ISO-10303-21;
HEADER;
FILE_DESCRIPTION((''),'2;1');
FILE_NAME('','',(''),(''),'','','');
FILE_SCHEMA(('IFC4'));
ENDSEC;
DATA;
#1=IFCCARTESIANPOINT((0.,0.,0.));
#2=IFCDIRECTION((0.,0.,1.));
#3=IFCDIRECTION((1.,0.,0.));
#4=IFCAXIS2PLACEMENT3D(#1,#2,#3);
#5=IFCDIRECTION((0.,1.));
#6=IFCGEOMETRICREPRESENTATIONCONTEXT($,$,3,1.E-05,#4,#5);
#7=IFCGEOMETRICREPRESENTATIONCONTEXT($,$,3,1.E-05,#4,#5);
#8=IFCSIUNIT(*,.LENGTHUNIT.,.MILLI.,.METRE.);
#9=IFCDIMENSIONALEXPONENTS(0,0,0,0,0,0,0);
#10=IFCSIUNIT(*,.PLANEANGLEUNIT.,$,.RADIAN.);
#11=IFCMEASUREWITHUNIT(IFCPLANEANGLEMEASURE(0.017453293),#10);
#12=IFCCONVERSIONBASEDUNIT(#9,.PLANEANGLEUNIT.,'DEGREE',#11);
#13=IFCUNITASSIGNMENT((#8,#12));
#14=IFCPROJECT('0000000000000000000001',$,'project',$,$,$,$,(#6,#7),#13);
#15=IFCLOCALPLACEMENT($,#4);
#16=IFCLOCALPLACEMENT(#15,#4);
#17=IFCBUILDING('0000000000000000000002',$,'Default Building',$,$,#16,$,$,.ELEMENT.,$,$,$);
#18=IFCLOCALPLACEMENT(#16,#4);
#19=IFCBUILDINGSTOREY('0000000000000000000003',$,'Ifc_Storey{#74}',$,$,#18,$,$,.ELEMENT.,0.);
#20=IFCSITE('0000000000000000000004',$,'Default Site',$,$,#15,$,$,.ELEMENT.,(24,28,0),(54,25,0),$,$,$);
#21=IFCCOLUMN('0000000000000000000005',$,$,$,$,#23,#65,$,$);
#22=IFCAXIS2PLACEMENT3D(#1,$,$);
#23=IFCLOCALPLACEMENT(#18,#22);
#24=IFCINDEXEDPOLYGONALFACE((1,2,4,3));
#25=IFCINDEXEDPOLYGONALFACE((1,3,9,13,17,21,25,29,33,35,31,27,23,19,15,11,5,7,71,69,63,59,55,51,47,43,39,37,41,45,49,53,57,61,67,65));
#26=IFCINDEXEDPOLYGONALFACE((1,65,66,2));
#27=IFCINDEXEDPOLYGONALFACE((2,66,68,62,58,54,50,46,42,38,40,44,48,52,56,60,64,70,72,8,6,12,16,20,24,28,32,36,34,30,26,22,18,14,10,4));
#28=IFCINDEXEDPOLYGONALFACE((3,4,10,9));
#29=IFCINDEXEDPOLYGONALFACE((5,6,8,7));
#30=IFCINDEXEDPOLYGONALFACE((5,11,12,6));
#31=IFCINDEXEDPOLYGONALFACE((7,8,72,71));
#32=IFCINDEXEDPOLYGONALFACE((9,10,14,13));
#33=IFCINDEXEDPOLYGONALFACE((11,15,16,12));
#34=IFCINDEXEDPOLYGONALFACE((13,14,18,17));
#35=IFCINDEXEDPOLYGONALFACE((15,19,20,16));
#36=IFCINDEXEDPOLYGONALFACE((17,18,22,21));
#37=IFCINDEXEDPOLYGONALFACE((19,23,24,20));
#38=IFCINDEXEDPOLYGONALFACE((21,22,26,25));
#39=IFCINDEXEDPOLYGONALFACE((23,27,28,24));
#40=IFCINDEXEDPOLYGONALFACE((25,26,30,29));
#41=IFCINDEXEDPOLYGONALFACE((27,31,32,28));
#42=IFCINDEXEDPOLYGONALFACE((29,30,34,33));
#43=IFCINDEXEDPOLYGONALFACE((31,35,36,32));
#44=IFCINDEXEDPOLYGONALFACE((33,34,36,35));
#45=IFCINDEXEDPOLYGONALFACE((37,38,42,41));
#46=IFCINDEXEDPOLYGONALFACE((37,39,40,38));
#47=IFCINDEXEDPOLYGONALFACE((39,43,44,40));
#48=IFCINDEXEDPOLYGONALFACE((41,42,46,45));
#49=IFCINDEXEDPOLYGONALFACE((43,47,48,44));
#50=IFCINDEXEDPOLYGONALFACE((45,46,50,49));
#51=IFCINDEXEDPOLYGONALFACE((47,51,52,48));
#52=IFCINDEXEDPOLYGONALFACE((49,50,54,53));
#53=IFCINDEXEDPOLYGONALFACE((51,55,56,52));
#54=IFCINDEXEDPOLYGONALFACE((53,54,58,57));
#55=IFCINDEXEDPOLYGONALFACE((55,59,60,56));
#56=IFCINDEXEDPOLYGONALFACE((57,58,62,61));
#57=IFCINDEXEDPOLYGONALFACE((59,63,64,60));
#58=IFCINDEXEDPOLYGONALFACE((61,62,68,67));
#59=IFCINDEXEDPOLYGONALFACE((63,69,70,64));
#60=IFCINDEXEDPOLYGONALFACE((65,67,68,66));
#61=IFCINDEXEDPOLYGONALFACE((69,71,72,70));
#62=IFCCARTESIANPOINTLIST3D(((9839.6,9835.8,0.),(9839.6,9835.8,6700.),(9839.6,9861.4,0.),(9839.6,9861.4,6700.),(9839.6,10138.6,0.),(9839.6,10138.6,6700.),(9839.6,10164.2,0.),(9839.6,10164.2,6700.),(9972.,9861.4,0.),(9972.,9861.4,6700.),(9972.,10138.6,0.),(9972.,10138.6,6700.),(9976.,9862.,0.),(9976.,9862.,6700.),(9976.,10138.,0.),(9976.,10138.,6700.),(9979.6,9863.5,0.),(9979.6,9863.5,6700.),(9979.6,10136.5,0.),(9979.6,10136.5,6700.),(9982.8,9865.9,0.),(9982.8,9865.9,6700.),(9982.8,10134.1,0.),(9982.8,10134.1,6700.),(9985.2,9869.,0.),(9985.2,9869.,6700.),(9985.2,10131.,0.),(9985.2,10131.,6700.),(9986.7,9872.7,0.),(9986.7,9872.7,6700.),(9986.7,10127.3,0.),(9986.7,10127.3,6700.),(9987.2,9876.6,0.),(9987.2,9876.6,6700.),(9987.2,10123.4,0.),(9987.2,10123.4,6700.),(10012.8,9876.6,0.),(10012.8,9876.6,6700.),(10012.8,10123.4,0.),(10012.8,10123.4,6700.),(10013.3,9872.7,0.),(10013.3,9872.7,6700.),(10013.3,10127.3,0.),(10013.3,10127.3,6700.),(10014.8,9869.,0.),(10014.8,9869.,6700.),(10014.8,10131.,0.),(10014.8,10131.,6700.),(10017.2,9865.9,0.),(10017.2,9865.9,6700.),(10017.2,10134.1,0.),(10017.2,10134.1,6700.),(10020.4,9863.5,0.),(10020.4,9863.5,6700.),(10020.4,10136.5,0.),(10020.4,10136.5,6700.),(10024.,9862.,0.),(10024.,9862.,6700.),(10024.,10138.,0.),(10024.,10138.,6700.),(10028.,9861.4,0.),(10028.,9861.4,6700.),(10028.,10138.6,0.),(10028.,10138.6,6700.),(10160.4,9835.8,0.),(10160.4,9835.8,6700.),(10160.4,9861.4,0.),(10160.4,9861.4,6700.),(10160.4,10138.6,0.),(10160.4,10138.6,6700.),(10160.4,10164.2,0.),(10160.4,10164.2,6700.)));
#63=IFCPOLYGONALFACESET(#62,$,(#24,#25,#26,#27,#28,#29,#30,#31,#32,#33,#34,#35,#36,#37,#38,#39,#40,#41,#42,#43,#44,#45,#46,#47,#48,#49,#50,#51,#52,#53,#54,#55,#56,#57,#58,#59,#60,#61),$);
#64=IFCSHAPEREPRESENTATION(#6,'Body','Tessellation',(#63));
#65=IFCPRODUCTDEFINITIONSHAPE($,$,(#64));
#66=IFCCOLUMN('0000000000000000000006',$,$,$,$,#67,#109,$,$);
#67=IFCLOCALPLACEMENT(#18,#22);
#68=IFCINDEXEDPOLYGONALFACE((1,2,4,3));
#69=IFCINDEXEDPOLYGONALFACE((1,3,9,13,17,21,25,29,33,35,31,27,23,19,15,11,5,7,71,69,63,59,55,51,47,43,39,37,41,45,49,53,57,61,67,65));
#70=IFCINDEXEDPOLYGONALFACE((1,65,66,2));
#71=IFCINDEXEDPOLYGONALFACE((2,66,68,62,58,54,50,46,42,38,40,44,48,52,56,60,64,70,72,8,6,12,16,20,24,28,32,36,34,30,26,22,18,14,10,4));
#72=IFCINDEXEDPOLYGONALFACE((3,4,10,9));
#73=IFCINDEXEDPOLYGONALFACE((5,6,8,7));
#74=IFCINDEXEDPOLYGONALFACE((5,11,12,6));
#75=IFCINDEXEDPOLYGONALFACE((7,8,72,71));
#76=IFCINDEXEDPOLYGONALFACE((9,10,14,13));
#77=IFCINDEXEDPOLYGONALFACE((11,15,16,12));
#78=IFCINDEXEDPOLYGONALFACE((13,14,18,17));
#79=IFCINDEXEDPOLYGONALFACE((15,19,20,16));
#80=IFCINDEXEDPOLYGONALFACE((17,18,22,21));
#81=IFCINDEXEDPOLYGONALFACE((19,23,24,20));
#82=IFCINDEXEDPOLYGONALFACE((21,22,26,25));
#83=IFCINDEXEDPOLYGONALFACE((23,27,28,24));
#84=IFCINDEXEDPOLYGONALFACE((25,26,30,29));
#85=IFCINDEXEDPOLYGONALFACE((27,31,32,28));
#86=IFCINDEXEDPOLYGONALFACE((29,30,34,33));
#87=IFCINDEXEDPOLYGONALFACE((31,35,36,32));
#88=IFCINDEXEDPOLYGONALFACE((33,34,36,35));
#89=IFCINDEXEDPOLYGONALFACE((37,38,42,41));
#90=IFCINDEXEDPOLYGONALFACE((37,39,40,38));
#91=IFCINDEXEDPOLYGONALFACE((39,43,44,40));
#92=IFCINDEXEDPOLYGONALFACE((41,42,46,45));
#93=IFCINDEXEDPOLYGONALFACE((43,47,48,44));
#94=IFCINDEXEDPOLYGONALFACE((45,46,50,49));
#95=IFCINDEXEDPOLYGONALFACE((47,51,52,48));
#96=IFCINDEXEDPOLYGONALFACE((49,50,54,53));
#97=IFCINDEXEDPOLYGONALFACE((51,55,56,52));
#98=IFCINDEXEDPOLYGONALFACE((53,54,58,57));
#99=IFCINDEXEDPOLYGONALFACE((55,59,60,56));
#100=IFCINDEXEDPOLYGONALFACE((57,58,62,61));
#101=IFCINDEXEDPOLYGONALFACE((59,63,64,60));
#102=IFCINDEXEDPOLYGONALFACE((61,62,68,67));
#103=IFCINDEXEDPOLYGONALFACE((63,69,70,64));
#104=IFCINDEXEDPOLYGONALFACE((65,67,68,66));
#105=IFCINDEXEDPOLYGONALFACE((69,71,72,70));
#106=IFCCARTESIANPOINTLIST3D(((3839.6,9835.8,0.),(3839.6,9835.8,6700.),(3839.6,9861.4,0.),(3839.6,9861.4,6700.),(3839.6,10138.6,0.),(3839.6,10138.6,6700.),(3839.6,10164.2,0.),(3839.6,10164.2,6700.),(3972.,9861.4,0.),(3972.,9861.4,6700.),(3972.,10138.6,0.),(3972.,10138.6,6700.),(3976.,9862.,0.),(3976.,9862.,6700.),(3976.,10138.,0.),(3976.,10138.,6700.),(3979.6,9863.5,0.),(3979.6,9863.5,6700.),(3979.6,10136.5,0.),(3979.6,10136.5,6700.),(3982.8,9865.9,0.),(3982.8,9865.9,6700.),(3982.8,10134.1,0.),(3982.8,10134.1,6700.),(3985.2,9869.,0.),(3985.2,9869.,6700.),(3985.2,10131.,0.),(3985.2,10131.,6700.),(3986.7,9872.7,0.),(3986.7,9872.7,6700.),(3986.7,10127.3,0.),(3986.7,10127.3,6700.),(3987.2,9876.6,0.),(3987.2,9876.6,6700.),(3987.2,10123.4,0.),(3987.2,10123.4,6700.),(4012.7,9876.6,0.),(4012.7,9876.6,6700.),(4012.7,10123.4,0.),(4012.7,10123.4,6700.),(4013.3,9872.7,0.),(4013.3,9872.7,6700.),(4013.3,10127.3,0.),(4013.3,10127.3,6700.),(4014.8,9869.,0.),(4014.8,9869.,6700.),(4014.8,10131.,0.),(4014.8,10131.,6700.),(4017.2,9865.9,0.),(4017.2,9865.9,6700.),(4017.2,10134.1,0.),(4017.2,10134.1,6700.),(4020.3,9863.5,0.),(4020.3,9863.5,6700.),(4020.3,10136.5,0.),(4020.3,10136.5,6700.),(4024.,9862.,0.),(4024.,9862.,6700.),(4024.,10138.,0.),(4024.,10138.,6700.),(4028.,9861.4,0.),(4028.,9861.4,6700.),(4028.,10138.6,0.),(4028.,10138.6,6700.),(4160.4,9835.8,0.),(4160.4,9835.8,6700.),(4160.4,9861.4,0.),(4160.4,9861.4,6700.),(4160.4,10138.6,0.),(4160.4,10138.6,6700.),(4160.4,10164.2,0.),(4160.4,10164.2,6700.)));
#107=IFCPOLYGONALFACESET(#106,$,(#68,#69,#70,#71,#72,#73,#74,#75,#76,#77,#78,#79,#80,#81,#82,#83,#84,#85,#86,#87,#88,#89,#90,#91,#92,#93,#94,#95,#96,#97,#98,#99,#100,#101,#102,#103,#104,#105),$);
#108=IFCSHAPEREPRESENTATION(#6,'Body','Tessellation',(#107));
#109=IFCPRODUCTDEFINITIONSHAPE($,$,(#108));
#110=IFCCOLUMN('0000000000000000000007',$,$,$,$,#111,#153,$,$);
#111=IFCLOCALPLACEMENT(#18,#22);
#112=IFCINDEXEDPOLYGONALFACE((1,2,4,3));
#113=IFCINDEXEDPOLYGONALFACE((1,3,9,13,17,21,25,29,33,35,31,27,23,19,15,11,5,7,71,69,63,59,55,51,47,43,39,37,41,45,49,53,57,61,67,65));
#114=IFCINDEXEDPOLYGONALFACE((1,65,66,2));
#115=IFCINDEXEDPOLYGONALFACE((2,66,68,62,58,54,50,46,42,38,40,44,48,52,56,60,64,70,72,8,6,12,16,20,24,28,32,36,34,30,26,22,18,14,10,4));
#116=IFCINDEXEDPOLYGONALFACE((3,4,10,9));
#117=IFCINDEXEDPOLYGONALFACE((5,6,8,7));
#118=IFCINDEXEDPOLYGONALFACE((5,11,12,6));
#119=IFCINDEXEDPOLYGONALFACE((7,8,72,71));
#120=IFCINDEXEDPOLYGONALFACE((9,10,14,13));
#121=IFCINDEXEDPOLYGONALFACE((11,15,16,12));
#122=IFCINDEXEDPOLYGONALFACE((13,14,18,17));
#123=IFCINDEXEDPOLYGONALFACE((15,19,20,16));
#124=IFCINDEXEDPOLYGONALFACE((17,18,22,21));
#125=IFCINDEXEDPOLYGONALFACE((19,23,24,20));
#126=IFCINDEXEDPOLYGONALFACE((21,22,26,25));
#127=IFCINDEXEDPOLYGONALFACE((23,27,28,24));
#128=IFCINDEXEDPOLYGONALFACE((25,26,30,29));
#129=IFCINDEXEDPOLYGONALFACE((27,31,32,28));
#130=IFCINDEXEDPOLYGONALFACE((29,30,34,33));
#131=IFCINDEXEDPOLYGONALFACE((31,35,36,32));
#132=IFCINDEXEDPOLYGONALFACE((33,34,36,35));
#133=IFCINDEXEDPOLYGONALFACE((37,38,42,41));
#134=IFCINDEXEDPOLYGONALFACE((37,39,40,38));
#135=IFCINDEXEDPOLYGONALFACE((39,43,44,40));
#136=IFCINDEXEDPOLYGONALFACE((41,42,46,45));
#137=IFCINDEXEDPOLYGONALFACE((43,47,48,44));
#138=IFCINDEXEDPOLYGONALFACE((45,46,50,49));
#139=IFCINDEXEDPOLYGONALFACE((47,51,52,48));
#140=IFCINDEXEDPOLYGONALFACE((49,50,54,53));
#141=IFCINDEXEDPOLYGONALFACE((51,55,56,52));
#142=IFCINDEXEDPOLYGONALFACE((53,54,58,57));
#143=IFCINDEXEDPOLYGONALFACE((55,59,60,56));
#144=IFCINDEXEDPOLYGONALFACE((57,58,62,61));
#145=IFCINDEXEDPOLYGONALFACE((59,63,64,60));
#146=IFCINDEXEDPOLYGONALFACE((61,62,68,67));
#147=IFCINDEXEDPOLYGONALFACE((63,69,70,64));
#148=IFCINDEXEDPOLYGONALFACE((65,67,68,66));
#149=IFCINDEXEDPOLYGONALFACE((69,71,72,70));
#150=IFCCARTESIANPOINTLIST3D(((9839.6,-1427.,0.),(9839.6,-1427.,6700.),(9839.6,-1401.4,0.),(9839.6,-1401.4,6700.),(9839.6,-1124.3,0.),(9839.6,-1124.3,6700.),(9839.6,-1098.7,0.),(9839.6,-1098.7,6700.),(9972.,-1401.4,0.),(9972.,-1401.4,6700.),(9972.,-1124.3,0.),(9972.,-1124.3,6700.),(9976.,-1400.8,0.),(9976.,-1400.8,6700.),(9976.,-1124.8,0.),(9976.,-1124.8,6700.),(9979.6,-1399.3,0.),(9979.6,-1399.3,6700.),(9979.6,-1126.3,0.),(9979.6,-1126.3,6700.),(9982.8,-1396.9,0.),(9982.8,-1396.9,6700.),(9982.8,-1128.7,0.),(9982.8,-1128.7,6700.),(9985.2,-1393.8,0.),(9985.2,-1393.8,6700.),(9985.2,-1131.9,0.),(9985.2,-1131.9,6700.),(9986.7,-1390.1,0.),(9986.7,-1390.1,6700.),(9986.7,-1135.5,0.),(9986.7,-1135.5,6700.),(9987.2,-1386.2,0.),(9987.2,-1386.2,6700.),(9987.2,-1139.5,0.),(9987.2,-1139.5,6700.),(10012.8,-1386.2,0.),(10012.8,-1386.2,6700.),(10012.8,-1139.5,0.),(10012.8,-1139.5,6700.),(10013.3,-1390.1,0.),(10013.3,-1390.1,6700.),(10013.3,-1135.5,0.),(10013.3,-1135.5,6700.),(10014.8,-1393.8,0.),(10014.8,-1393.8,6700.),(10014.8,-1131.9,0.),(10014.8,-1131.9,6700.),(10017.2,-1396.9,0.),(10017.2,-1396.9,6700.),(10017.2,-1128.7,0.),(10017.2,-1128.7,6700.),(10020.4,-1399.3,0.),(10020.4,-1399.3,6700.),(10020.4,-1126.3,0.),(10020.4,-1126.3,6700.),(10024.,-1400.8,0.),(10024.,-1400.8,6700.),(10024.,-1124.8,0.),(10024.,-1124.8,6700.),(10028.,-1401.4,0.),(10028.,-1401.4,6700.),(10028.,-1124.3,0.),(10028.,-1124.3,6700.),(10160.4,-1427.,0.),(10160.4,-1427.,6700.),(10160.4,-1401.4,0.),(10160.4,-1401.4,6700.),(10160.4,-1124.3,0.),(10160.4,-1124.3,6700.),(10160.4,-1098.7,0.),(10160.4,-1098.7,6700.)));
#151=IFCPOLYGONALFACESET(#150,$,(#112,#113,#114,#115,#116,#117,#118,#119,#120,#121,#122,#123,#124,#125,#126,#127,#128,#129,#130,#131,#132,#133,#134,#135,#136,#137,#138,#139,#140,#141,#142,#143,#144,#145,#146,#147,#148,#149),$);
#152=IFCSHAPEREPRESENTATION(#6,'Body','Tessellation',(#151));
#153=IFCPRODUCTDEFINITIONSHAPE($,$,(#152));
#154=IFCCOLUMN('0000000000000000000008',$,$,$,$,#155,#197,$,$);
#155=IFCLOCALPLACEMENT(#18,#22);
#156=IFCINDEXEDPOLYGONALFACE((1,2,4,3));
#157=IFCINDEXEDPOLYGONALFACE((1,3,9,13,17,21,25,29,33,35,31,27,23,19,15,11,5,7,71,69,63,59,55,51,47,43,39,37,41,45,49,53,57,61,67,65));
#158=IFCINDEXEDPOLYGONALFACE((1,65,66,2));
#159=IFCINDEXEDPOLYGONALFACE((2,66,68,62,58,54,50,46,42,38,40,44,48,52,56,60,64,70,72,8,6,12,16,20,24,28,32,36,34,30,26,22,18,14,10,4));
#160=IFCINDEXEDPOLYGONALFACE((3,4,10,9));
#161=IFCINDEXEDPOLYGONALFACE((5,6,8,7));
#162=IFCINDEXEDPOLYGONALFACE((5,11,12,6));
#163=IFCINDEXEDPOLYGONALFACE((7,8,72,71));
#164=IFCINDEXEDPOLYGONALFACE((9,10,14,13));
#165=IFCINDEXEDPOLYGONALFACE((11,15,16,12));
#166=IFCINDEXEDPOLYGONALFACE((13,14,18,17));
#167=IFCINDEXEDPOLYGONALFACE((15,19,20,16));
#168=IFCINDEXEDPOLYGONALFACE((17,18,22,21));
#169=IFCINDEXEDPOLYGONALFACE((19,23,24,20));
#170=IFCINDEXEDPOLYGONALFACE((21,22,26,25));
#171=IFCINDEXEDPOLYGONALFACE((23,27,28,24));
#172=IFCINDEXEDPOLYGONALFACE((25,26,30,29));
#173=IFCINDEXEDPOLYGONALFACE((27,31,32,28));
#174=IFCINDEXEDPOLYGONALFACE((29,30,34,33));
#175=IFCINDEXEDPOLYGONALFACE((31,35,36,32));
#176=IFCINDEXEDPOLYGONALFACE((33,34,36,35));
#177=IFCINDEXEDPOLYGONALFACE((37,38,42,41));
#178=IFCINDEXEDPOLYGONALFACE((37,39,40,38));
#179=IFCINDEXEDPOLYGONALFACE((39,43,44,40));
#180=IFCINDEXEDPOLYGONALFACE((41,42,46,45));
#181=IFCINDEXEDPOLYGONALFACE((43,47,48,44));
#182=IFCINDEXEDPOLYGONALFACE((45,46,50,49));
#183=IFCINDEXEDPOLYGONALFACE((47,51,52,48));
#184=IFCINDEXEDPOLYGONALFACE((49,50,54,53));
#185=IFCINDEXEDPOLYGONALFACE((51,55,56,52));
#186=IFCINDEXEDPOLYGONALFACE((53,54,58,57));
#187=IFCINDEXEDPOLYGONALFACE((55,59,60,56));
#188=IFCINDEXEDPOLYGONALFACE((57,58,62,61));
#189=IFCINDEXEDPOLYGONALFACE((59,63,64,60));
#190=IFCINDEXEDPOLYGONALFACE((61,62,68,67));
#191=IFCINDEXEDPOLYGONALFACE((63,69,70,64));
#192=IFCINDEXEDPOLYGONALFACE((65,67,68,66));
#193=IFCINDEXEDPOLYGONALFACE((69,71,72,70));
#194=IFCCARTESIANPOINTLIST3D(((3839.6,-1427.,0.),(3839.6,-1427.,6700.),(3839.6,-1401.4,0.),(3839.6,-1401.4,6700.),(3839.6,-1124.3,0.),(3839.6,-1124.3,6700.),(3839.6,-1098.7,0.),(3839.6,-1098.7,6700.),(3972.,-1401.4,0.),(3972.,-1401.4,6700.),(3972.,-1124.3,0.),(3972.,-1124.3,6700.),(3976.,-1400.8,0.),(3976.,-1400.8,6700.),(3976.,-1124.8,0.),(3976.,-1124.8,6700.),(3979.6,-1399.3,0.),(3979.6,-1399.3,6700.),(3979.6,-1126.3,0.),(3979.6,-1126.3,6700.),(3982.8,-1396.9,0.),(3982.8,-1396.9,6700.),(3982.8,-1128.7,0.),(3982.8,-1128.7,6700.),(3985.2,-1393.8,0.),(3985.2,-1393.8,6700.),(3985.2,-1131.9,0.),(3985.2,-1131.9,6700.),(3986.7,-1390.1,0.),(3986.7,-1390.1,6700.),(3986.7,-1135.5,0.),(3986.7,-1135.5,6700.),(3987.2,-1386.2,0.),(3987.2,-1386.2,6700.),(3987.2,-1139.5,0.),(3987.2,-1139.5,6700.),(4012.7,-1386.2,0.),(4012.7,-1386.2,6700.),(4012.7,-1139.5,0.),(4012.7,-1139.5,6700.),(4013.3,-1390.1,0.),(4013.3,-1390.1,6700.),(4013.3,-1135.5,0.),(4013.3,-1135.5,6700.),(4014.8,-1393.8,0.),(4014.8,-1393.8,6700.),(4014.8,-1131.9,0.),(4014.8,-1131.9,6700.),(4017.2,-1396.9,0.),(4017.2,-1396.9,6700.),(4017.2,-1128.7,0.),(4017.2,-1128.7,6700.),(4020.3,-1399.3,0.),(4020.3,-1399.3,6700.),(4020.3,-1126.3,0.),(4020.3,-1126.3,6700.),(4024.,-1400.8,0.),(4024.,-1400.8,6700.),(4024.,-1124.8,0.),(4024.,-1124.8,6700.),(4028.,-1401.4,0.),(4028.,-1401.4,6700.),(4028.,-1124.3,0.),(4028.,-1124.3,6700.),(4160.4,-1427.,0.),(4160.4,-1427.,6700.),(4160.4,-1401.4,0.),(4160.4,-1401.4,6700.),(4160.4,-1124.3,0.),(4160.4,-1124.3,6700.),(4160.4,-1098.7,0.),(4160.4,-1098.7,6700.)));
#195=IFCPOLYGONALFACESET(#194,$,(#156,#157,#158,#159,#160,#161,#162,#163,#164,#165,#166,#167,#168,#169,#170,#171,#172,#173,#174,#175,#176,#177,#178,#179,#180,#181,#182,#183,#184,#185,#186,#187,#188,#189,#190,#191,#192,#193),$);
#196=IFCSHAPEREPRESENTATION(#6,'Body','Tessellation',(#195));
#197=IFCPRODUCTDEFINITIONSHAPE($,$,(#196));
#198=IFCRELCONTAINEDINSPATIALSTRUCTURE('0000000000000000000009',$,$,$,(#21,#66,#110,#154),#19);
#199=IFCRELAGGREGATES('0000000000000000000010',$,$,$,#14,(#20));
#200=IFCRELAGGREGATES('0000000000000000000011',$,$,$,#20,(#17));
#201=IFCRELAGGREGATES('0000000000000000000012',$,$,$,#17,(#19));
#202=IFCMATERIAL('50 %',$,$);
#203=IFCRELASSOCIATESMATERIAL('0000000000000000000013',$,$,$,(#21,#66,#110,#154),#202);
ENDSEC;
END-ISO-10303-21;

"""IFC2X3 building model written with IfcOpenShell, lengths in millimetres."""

from ifc_helpers import new_model, entity, si_unit, converted_unit, direction, frame, origin_with_axes, origin_2d_with_axis, place, context, project, spatial, i_section, extrude, material, element, save


model = new_model("IFC2X3")

# Units and contexts
context_of_model_1 = context(None, 3, precision=1e-05, world=origin_with_axes(), true_north=direction((0.0, 1.0)))
context_of_model_2 = context(None, 3, precision=1e-05, world=origin_with_axes(), true_north=direction((0.0, 1.0)))
ifc_project = project(units=[si_unit("LENGTHUNIT", "METRE", prefix="MILLI"), converted_unit("PLANEANGLEUNIT", "DEGREE", entity("IfcPlaneAngleMeasure", 0.017453293), si_unit("PLANEANGLEUNIT", "RADIAN"), dimensions=[0, 0, 0, 0, 0, 0, 0])], contexts=[context_of_model_1, context_of_model_2])

# Site, building, storey
site_placement = place(None, origin_with_axes())
site = spatial("IfcSite", under=ifc_project, at=site_placement, Name="Default Site", CompositionType="ELEMENT", RefLatitude=(24, 28, 0), RefLongitude=(54, 25, 0))
building_placement = place(site_placement, origin_with_axes())
building = spatial("IfcBuilding", under=site, at=building_placement, Name="Default Building", CompositionType="ELEMENT")
storey_placement = place(building_placement, origin_with_axes())
storey = spatial("IfcBuildingStorey", under=building, at=storey_placement, Name="Ifc_Storey{#74}", CompositionType="ELEMENT", Elevation=0.0)

# Columns
ifc_material_1 = material(Name="50 %")
for number, where, z_axis, x_axis in (
    (1, (10000.0, 10000.0, 0.0), (0.0, 0.0, 1.0), (1.0, 0.0, 0.0)),
    (2, (4000.0, 10000.0, 0.0), (0.0, 0.0, 1.0), (1.0, 0.0, 0.0)),
):
    element("IfcColumn", number, at=place(storey_placement, frame(where, z_axis=z_axis, x_axis=x_axis)), inside=storey, material=ifc_material_1, context=context_of_model_1, shape_type="SweptSolid", body=[
        extrude(i_section(OverallWidth=320.9, OverallDepth=328.3, WebThickness=25.5, FlangeThickness=25.6, FilletRadius=15.2, at=origin_2d_with_axis()), origin_with_axes(), (0.0, 0.0, 1.0), 6700.0),
    ])
for number, where, z_axis, x_axis in (
    (3, (10000.0, -1262.8, 0.0), (0.0, 0.0, 1.0), (-1.0, 0.0, 0.0)),
    (4, (4000.0, -1262.8, 0.0), (0.0, 0.0, 1.0), (-1.0, 0.0, 0.0)),
):
    element("IfcColumn", number, at=place(storey_placement, frame(where, z_axis=z_axis, x_axis=x_axis)), inside=storey, material=ifc_material_1, context=context_of_model_1, shape_type="SweptSolid", body=[
        extrude(i_section(OverallWidth=320.9, OverallDepth=328.3, WebThickness=25.5, FlangeThickness=25.6, FilletRadius=15.2, at=origin_2d_with_axis()), frame((0.0, 0.0, 0.0), z_axis=(0.0, 0.0, 1.0), x_axis=(-1.0, 0.0, 0.0)), (0.0, 0.0, 1.0), 6700.0),
    ])

save(model, "model.ifc")
